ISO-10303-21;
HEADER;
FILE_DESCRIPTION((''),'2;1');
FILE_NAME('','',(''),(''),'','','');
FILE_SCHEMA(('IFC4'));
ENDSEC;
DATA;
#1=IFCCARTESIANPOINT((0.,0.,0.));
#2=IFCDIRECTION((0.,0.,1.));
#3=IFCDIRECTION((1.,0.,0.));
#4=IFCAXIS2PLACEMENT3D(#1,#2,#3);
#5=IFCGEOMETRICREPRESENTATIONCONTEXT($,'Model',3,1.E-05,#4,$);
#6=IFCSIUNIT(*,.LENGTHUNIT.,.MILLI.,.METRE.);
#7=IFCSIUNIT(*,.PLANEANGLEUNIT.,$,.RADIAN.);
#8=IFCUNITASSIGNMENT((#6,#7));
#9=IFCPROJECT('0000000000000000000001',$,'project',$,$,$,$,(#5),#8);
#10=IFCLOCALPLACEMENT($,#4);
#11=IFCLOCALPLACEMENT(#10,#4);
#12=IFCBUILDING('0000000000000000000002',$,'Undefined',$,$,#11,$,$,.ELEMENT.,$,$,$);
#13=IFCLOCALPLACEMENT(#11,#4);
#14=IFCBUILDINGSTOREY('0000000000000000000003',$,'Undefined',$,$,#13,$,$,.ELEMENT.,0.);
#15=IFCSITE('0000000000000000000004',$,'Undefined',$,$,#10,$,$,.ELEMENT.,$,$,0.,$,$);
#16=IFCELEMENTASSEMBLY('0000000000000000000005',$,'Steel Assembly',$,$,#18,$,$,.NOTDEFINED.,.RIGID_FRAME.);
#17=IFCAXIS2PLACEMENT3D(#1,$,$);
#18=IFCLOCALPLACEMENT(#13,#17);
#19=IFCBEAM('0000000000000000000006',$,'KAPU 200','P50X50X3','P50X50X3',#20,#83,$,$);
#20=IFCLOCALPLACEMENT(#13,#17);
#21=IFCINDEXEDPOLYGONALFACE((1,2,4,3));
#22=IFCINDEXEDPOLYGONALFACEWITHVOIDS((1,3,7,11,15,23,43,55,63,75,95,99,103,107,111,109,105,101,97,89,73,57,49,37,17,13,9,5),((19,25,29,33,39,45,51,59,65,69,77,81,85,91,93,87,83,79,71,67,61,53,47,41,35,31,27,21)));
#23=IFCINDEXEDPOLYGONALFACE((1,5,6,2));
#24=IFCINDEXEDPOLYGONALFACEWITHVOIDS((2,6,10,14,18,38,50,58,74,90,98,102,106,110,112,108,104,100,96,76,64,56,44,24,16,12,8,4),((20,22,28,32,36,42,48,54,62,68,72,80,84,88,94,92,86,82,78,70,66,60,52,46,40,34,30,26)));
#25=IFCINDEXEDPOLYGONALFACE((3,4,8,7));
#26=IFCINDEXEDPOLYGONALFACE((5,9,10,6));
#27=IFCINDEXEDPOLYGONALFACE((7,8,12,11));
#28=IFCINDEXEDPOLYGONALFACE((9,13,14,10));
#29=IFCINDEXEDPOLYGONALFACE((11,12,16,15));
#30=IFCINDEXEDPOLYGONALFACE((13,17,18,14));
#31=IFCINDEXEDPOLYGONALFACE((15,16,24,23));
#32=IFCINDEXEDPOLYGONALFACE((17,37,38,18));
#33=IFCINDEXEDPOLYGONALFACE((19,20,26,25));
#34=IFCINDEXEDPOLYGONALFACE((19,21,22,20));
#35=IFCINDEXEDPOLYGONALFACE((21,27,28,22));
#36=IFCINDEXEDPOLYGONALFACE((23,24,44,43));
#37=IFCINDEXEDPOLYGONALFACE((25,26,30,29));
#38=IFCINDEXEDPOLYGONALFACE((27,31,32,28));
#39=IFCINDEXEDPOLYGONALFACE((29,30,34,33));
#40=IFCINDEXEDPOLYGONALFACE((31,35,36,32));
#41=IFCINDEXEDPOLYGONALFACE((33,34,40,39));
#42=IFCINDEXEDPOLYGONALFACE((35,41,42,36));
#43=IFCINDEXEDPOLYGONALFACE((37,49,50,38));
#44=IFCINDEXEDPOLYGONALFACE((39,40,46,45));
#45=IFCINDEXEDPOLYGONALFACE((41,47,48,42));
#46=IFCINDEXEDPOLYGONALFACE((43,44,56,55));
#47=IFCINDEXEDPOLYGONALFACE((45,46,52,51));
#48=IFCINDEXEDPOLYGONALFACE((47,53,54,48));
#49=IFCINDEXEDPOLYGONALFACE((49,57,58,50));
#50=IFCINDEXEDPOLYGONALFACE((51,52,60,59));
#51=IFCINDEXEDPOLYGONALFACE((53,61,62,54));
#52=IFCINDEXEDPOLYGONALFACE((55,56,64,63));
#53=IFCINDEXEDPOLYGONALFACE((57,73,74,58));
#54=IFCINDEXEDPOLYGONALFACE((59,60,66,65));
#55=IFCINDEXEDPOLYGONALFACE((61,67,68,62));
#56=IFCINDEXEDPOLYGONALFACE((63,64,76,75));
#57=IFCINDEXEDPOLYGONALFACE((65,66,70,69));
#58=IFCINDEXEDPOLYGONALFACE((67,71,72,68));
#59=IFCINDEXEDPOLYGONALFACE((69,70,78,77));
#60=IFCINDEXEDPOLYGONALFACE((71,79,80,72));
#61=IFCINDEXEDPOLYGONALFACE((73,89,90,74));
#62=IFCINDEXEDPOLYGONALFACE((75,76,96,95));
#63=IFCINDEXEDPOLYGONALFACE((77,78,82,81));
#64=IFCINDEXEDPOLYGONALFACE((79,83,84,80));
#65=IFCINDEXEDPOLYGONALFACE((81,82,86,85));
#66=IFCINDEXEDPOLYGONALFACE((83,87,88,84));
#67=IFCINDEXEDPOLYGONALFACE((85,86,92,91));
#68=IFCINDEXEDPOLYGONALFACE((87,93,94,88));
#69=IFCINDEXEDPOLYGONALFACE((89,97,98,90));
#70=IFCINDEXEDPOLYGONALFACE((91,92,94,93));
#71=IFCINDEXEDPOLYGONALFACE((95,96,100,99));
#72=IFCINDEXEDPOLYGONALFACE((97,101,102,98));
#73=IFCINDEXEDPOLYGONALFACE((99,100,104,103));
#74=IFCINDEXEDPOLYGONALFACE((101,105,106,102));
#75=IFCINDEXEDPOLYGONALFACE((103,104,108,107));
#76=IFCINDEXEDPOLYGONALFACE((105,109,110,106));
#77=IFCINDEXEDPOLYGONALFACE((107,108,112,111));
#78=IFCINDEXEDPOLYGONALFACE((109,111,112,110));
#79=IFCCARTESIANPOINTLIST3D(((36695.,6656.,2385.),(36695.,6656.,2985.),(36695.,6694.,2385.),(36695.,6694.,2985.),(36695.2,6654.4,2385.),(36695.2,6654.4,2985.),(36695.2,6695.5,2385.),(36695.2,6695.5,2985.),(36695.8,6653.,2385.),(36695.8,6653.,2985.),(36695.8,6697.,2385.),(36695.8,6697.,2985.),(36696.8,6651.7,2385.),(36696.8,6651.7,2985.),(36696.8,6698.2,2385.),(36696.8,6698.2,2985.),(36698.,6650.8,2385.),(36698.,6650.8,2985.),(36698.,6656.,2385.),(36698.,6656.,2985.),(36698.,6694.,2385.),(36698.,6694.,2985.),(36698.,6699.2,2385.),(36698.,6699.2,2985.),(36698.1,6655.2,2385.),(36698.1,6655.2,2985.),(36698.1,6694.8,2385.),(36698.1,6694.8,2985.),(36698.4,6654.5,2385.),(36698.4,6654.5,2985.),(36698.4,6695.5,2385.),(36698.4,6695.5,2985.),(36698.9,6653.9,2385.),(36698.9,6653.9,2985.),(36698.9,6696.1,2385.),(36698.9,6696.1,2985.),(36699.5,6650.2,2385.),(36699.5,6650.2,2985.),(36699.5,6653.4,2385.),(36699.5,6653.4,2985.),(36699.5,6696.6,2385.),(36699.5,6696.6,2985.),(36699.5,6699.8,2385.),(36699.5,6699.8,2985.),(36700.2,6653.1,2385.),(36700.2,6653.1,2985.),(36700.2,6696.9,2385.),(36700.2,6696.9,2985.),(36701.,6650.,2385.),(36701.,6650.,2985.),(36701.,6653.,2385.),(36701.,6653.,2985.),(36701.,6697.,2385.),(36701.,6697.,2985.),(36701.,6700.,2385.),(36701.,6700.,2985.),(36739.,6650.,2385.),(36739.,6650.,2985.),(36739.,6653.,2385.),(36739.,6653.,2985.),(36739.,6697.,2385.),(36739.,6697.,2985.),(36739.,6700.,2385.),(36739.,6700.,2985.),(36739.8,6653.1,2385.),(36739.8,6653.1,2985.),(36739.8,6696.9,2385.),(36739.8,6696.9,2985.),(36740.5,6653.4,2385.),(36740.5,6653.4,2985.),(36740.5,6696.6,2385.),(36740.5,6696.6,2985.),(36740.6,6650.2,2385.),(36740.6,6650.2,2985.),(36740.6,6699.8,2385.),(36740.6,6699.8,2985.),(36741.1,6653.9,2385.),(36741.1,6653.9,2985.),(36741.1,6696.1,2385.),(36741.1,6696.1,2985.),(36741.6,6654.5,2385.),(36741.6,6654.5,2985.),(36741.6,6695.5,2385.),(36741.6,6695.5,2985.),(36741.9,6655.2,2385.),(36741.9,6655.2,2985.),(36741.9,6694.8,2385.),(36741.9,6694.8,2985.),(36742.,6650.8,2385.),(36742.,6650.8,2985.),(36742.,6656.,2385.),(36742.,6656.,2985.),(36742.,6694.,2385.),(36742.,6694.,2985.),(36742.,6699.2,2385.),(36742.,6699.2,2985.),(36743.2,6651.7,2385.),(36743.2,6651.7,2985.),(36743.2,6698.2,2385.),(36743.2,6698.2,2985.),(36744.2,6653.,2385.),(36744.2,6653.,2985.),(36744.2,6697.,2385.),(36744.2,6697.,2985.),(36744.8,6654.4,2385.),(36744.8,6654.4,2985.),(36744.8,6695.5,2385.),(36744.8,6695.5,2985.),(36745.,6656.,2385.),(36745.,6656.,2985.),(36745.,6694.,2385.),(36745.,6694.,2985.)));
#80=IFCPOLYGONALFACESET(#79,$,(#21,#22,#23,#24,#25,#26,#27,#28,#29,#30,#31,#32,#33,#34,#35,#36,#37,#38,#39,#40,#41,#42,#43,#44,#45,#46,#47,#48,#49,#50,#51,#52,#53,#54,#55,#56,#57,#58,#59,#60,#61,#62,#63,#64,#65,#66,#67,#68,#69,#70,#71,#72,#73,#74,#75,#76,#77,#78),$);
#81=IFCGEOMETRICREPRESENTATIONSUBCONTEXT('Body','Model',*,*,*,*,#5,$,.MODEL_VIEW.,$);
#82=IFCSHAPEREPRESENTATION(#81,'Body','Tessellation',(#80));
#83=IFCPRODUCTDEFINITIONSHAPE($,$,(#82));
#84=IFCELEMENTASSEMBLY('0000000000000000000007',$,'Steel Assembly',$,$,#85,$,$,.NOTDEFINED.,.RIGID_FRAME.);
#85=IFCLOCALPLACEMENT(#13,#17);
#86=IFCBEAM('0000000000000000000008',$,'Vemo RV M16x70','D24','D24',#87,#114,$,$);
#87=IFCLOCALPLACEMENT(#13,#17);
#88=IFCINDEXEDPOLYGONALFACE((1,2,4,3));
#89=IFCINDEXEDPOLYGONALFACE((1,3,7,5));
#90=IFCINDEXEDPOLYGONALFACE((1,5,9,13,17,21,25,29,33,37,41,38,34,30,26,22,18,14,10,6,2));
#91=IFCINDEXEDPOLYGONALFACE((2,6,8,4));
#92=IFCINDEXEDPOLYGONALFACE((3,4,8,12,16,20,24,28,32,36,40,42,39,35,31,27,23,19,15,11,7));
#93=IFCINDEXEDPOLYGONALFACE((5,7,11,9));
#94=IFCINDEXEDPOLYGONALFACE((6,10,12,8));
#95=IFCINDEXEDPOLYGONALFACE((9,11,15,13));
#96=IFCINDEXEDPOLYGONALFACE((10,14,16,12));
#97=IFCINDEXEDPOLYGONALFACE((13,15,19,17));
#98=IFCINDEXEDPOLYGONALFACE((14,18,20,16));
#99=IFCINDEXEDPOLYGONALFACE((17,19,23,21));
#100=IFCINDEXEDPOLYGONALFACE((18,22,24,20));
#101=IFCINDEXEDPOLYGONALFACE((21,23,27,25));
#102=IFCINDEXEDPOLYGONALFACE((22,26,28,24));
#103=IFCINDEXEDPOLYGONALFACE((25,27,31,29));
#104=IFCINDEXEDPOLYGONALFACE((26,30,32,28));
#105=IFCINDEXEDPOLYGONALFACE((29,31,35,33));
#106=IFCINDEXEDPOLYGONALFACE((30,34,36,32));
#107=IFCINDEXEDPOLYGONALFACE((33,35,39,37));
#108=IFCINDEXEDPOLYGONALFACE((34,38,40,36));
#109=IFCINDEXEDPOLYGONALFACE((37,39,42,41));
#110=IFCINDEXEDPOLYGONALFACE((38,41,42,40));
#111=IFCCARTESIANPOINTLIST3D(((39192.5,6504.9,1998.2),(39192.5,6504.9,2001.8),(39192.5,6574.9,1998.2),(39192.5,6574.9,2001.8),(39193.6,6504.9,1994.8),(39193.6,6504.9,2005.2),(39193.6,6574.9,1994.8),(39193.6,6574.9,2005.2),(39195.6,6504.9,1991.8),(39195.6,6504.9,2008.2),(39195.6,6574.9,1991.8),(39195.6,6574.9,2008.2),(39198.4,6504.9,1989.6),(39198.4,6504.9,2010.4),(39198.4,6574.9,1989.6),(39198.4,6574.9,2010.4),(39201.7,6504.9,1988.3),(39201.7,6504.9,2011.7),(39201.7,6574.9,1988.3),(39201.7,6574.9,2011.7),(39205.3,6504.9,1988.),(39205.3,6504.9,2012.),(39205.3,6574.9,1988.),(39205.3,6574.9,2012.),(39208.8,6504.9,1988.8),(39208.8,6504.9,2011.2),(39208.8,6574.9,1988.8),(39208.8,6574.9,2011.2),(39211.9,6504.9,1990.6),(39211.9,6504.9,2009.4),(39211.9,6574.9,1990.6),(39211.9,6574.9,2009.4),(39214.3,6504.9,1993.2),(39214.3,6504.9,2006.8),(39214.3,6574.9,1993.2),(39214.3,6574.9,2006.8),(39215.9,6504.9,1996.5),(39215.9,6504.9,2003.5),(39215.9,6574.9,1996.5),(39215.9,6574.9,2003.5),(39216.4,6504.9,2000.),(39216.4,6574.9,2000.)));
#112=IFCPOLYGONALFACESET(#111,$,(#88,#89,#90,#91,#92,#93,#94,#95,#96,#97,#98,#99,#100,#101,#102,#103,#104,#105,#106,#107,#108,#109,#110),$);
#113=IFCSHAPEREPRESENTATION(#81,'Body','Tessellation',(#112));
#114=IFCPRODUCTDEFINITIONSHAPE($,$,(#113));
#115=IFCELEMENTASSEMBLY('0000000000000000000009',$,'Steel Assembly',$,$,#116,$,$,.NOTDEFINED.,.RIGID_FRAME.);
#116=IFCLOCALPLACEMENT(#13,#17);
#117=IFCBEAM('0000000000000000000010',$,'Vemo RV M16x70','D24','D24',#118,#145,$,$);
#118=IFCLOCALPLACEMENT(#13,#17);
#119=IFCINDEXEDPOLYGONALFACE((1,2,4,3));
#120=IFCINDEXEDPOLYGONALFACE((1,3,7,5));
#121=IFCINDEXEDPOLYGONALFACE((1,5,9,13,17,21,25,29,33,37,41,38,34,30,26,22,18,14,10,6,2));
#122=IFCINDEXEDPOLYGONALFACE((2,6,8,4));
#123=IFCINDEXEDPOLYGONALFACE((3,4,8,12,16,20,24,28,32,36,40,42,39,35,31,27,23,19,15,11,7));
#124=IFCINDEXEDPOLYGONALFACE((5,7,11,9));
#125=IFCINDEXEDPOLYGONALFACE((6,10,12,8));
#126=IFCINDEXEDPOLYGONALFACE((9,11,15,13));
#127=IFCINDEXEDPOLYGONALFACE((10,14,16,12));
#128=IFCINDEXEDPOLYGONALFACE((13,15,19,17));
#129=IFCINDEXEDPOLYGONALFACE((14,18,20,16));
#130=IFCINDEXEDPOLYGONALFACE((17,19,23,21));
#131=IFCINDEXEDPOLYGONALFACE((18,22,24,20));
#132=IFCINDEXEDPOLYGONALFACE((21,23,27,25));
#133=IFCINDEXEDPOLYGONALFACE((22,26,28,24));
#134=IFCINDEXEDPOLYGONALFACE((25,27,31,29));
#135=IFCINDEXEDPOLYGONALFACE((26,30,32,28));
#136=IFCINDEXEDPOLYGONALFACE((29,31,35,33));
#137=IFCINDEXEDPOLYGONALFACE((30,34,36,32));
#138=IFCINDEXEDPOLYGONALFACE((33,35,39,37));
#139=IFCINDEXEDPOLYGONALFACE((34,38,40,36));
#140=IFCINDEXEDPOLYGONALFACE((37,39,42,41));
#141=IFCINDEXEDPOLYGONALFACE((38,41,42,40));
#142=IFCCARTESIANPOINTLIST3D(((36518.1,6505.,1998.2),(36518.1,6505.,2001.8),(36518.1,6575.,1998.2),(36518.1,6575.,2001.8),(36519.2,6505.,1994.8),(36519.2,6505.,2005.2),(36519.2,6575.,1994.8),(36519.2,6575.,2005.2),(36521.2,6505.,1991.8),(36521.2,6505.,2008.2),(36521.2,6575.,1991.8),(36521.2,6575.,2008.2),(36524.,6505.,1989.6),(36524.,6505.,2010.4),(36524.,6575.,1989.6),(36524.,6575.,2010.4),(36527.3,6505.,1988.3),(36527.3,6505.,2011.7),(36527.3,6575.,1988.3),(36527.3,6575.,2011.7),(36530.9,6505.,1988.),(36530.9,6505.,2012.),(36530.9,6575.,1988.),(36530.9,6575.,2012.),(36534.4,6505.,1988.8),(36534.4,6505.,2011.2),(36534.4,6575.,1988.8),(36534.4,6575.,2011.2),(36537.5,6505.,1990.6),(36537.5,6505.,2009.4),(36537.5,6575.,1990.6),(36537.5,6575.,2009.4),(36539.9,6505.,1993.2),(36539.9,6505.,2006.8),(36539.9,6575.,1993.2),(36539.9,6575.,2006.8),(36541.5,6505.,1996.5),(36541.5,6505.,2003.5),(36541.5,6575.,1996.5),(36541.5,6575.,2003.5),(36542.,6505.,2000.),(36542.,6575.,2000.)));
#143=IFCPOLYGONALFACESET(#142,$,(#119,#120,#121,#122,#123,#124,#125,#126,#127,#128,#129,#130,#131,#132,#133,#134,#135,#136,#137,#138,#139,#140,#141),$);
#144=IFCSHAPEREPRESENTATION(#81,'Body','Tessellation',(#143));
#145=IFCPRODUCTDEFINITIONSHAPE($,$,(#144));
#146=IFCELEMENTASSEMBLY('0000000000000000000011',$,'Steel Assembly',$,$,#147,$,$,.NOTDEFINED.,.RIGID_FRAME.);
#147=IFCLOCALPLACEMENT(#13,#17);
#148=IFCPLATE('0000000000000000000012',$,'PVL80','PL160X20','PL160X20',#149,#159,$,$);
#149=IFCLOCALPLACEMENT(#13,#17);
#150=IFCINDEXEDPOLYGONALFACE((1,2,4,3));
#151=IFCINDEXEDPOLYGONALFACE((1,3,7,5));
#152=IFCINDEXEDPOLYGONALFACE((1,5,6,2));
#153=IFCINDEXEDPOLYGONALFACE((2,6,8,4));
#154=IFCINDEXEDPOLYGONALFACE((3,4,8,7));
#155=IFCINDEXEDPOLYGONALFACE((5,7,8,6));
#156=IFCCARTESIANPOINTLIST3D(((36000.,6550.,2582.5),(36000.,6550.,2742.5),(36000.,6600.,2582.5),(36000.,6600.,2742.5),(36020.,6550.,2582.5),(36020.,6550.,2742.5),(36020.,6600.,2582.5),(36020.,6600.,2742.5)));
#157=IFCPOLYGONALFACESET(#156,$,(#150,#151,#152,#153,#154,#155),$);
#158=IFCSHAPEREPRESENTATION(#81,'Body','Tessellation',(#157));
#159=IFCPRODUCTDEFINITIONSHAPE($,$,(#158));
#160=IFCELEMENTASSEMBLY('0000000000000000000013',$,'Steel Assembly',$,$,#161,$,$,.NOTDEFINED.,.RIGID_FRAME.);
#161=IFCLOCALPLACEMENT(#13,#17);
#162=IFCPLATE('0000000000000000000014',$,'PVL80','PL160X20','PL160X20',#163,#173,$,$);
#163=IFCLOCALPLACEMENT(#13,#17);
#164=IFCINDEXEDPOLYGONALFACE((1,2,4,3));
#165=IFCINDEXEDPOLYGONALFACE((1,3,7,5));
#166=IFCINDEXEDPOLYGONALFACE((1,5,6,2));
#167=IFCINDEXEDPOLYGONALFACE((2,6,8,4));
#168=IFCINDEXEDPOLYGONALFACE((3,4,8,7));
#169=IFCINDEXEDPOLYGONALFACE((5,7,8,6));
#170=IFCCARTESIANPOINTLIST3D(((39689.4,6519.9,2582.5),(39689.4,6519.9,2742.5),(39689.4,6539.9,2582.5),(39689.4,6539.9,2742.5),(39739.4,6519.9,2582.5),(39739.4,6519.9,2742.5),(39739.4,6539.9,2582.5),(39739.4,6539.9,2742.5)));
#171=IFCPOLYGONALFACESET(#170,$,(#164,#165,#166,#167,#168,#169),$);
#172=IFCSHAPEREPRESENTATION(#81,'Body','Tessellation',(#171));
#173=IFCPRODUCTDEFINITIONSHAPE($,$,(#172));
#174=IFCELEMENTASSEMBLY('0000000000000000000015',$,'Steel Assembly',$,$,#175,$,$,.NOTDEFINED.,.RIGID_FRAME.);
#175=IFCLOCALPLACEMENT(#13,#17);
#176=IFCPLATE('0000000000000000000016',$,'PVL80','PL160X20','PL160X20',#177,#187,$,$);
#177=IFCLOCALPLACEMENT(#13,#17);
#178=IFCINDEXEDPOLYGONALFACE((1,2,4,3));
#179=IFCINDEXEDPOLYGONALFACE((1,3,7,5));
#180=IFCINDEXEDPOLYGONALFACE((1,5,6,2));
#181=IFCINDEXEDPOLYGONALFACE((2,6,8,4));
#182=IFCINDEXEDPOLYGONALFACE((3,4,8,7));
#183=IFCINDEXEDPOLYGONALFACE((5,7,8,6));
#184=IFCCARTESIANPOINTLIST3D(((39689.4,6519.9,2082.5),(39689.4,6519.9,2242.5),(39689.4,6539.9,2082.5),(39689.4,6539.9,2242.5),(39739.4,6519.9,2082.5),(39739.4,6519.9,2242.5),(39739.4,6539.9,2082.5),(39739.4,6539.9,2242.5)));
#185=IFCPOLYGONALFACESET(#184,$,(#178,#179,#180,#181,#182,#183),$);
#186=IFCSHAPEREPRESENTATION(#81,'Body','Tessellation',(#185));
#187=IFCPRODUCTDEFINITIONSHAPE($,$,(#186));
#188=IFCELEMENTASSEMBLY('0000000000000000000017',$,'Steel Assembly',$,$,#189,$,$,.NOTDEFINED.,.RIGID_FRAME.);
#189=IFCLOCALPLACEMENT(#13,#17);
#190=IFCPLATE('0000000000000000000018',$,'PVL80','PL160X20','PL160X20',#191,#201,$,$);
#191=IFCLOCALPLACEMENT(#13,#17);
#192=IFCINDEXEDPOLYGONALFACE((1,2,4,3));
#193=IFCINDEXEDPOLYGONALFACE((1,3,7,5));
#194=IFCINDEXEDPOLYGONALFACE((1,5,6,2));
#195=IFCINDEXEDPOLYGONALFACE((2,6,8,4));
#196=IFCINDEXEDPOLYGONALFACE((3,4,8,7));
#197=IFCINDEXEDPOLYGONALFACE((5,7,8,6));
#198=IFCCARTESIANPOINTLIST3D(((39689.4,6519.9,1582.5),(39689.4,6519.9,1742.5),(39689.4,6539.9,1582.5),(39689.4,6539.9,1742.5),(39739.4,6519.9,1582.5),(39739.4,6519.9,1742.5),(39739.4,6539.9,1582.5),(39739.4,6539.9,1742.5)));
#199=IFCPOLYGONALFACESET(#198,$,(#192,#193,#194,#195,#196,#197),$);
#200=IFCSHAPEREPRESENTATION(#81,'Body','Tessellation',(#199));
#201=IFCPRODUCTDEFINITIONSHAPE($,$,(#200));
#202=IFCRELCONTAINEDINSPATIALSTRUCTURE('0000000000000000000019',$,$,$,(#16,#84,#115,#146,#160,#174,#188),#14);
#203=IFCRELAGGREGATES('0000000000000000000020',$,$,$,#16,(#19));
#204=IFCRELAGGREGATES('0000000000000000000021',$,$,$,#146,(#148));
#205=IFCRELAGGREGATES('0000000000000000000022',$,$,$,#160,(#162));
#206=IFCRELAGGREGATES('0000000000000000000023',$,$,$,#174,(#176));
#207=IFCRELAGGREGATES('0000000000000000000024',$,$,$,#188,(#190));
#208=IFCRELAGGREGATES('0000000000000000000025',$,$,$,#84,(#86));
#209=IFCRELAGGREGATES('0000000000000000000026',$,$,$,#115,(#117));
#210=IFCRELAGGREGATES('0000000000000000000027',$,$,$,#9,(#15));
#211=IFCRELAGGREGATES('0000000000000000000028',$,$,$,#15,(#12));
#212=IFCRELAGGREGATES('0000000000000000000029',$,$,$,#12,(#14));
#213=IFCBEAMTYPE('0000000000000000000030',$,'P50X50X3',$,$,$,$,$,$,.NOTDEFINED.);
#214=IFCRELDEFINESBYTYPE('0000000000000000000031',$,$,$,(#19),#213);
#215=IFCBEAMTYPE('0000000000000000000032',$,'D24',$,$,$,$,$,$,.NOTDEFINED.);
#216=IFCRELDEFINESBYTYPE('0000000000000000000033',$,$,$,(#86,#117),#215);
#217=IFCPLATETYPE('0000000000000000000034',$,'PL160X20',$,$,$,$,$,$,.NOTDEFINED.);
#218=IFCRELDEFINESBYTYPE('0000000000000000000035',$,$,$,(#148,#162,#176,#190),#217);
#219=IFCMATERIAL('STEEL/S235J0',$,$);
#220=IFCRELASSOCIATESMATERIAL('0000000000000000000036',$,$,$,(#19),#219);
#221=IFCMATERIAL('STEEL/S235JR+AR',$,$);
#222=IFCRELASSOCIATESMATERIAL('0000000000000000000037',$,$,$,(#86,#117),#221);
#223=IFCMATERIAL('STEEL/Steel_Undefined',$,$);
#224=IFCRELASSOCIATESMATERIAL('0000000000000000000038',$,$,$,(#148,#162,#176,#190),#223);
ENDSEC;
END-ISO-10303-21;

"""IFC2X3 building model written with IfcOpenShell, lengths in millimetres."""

from ifc_helpers import new_model, si_unit, frame, origin_with_axes, origin_2d_with_axis, place, context, subcontext, project, spatial, polyline, hollow_rectangle, circle, outline, extrude, material, type_object, element, aggregate, save


model = new_model("IFC2X3")

# Units and contexts
model_context = context("Model", 3, precision=1e-05, world=origin_with_axes())
body_context = subcontext(model_context, "Body", "Model", "MODEL_VIEW")
ifc_project = project(units=[si_unit("LENGTHUNIT", "METRE", prefix="MILLI"), si_unit("PLANEANGLEUNIT", "RADIAN")], contexts=[model_context])

# Site, building, storey
site_placement = place(None, origin_with_axes())
site = spatial("IfcSite", under=ifc_project, at=site_placement, Name="Undefined", CompositionType="ELEMENT", RefElevation=0.0)
building_placement = place(site_placement, origin_with_axes())
building = spatial("IfcBuilding", under=site, at=building_placement, Name="Undefined", CompositionType="ELEMENT")
storey_placement = place(building_placement, origin_with_axes())
storey = spatial("IfcBuildingStorey", under=building, at=storey_placement, Name="Undefined", CompositionType="ELEMENT", Elevation=0.0)

# Element assemblies, beams
ifc_material_1 = material(Name="STEEL/S235J0")
beam_type_1 = type_object("IfcBeamType", Name="P50X50X3", PredefinedType="NOTDEFINED")
assembly_1_placement = place(storey_placement, origin_with_axes())
assembly_1 = element("IfcElementAssembly", 1, at=assembly_1_placement, inside=storey, Name="Steel Assembly", AssemblyPlace="NOTDEFINED", PredefinedType="RIGID_FRAME")
beam_1_placement = place(assembly_1_placement, frame((36720.0, 6675.0, 2985.0), z_axis=(1.0, -0.00003, 0.0), x_axis=(0.0, 0.0, -1.0)))
beam_1 = element("IfcBeam", 2, at=beam_1_placement, type_object=beam_type_1, material=ifc_material_1, Name="KAPU 200", Description="P50X50X3", ObjectType="P50X50X3", context=body_context, shape_type="SweptSolid", body=[
    extrude(hollow_rectangle(XDim=50.0, YDim=50.0, WallThickness=3.0, InnerFilletRadius=3.0, OuterFilletRadius=6.0, at=origin_2d_with_axis()), frame((600.0, 0.0, 0.0), z_axis=(-1.0, 0.0, 0.0), x_axis=(0.0, -1.0, 0.0)), (0.0, 0.0, 1.0), 600.0),
])
aggregate(assembly_1, [beam_1])
assembly_2_placement = place(storey_placement, origin_with_axes())
assembly_2 = element("IfcElementAssembly", 3, at=assembly_2_placement, inside=storey, Name="Steel Assembly", AssemblyPlace="NOTDEFINED", PredefinedType="RIGID_FRAME")
ifc_material_2 = material(Name="STEEL/S235JR+AR")
beam_type_2 = type_object("IfcBeamType", Name="D24", PredefinedType="NOTDEFINED")
beam_2_placement = place(assembly_2_placement, frame((39204.4, 6504.9, 2000.0), z_axis=(0.0, 0.0, 1.0), x_axis=(0.00003, 1.0, 0.0)))
beam_2 = element("IfcBeam", 4, at=beam_2_placement, type_object=beam_type_2, material=ifc_material_2, Name="Vemo RV M16x70", Description="D24", ObjectType="D24", context=body_context, shape_type="SweptSolid", body=[
    extrude(circle(Radius=12.0, at=origin_2d_with_axis()), frame((70.0, 0.0, 0.0), z_axis=(-1.0, 0.0, 0.0), x_axis=(0.0, -1.0, 0.0)), (0.0, 0.0, 1.0), 70.0),
])
assembly_3_placement = place(storey_placement, origin_with_axes())
assembly_3 = element("IfcElementAssembly", 5, at=assembly_3_placement, inside=storey, Name="Steel Assembly", AssemblyPlace="NOTDEFINED", PredefinedType="RIGID_FRAME")
beam_3_placement = place(assembly_3_placement, frame((36530.0, 6505.0, 2000.0), z_axis=(0.0, 0.0, 1.0), x_axis=(0.00003, 1.0, 0.0)))
beam_3 = element("IfcBeam", 6, at=beam_3_placement, type_object=beam_type_2, material=ifc_material_2, Name="Vemo RV M16x70", Description="D24", ObjectType="D24", context=body_context, shape_type="SweptSolid", body=[
    extrude(circle(Radius=12.0, at=origin_2d_with_axis()), frame((70.0, 0.0, 0.0), z_axis=(-1.0, 0.0, 0.0), x_axis=(0.0, -1.0, 0.0)), (0.0, 0.0, 1.0), 70.0),
])

# Element assemblies, plates
assembly_4_placement = place(storey_placement, origin_with_axes())
assembly_4 = element("IfcElementAssembly", 7, at=assembly_4_placement, inside=storey, Name="Steel Assembly", AssemblyPlace="NOTDEFINED", PredefinedType="RIGID_FRAME")
ifc_material_3 = material(Name="STEEL/Steel_Undefined")
plate_type = type_object("IfcPlateType", Name="PL160X20", PredefinedType="NOTDEFINED")
plate_1_placement = place(assembly_4_placement, frame((36000.0, 6550.0, 2662.5), z_axis=(0.0, 0.0, -1.0), x_axis=(0.00003, 1.0, 0.0)))
plate_1 = element("IfcPlate", 8, at=plate_1_placement, type_object=plate_type, material=ifc_material_3, Name="PVL80", Description="PL160X20", ObjectType="PL160X20", context=body_context, shape_type="SweptSolid", body=[
    extrude(outline(polyline([(0.0, 0.0), (50.0, 0.0), (50.0, 20.0), (0.0, 20.0), (0.0, 0.0)])), frame((0.0, 0.0, -80.0), z_axis=(0.0, 0.0, 1.0), x_axis=(1.0, 0.0, 0.0)), (0.0, 0.0, 1.0), 160.0),
])
assembly_5_placement = place(storey_placement, origin_with_axes())
assembly_5 = element("IfcElementAssembly", 9, at=assembly_5_placement, inside=storey, Name="Steel Assembly", AssemblyPlace="NOTDEFINED", PredefinedType="RIGID_FRAME")
plate_2_placement = place(assembly_5_placement, frame((39739.4, 6519.9, 2662.5), z_axis=(0.0, 0.0, -1.0), x_axis=(-1.0, 0.00003, 0.0)))
plate_2 = element("IfcPlate", 10, at=plate_2_placement, type_object=plate_type, material=ifc_material_3, Name="PVL80", Description="PL160X20", ObjectType="PL160X20", context=body_context, shape_type="SweptSolid", body=[
    extrude(outline(polyline([(0.0, 0.0), (50.0, 0.0), (50.0, 20.0), (0.0, 20.0), (0.0, 0.0)])), frame((0.0, 0.0, -80.0), z_axis=(0.0, 0.0, 1.0), x_axis=(1.0, 0.0, 0.0)), (0.0, 0.0, 1.0), 160.0),
])
assembly_6_placement = place(storey_placement, origin_with_axes())
assembly_6 = element("IfcElementAssembly", 11, at=assembly_6_placement, inside=storey, Name="Steel Assembly", AssemblyPlace="NOTDEFINED", PredefinedType="RIGID_FRAME")
plate_3_placement = place(assembly_6_placement, frame((39739.4, 6519.9, 2162.5), z_axis=(0.0, 0.0, -1.0), x_axis=(-1.0, 0.00003, 0.0)))
plate_3 = element("IfcPlate", 12, at=plate_3_placement, type_object=plate_type, material=ifc_material_3, Name="PVL80", Description="PL160X20", ObjectType="PL160X20", context=body_context, shape_type="SweptSolid", body=[
    extrude(outline(polyline([(0.0, 0.0), (50.0, 0.0), (50.0, 20.0), (0.0, 20.0), (0.0, 0.0)])), frame((0.0, 0.0, -80.0), z_axis=(0.0, 0.0, 1.0), x_axis=(1.0, 0.0, 0.0)), (0.0, 0.0, 1.0), 160.0),
])
assembly_7_placement = place(storey_placement, origin_with_axes())
assembly_7 = element("IfcElementAssembly", 13, at=assembly_7_placement, inside=storey, Name="Steel Assembly", AssemblyPlace="NOTDEFINED", PredefinedType="RIGID_FRAME")
plate_4_placement = place(assembly_7_placement, frame((39739.4, 6519.9, 1662.5), z_axis=(0.0, 0.0, -1.0), x_axis=(-1.0, 0.00003, 0.0)))
plate_4 = element("IfcPlate", 14, at=plate_4_placement, type_object=plate_type, material=ifc_material_3, Name="PVL80", Description="PL160X20", ObjectType="PL160X20", context=body_context, shape_type="SweptSolid", body=[
    extrude(outline(polyline([(0.0, 0.0), (50.0, 0.0), (50.0, 20.0), (0.0, 20.0), (0.0, 0.0)])), frame((0.0, 0.0, -80.0), z_axis=(0.0, 0.0, 1.0), x_axis=(1.0, 0.0, 0.0)), (0.0, 0.0, 1.0), 160.0),
])

aggregate(assembly_4, [plate_1])
aggregate(assembly_5, [plate_2])
aggregate(assembly_6, [plate_3])
aggregate(assembly_7, [plate_4])

aggregate(assembly_2, [beam_2])
aggregate(assembly_3, [beam_3])

save(model, "model.ifc")
